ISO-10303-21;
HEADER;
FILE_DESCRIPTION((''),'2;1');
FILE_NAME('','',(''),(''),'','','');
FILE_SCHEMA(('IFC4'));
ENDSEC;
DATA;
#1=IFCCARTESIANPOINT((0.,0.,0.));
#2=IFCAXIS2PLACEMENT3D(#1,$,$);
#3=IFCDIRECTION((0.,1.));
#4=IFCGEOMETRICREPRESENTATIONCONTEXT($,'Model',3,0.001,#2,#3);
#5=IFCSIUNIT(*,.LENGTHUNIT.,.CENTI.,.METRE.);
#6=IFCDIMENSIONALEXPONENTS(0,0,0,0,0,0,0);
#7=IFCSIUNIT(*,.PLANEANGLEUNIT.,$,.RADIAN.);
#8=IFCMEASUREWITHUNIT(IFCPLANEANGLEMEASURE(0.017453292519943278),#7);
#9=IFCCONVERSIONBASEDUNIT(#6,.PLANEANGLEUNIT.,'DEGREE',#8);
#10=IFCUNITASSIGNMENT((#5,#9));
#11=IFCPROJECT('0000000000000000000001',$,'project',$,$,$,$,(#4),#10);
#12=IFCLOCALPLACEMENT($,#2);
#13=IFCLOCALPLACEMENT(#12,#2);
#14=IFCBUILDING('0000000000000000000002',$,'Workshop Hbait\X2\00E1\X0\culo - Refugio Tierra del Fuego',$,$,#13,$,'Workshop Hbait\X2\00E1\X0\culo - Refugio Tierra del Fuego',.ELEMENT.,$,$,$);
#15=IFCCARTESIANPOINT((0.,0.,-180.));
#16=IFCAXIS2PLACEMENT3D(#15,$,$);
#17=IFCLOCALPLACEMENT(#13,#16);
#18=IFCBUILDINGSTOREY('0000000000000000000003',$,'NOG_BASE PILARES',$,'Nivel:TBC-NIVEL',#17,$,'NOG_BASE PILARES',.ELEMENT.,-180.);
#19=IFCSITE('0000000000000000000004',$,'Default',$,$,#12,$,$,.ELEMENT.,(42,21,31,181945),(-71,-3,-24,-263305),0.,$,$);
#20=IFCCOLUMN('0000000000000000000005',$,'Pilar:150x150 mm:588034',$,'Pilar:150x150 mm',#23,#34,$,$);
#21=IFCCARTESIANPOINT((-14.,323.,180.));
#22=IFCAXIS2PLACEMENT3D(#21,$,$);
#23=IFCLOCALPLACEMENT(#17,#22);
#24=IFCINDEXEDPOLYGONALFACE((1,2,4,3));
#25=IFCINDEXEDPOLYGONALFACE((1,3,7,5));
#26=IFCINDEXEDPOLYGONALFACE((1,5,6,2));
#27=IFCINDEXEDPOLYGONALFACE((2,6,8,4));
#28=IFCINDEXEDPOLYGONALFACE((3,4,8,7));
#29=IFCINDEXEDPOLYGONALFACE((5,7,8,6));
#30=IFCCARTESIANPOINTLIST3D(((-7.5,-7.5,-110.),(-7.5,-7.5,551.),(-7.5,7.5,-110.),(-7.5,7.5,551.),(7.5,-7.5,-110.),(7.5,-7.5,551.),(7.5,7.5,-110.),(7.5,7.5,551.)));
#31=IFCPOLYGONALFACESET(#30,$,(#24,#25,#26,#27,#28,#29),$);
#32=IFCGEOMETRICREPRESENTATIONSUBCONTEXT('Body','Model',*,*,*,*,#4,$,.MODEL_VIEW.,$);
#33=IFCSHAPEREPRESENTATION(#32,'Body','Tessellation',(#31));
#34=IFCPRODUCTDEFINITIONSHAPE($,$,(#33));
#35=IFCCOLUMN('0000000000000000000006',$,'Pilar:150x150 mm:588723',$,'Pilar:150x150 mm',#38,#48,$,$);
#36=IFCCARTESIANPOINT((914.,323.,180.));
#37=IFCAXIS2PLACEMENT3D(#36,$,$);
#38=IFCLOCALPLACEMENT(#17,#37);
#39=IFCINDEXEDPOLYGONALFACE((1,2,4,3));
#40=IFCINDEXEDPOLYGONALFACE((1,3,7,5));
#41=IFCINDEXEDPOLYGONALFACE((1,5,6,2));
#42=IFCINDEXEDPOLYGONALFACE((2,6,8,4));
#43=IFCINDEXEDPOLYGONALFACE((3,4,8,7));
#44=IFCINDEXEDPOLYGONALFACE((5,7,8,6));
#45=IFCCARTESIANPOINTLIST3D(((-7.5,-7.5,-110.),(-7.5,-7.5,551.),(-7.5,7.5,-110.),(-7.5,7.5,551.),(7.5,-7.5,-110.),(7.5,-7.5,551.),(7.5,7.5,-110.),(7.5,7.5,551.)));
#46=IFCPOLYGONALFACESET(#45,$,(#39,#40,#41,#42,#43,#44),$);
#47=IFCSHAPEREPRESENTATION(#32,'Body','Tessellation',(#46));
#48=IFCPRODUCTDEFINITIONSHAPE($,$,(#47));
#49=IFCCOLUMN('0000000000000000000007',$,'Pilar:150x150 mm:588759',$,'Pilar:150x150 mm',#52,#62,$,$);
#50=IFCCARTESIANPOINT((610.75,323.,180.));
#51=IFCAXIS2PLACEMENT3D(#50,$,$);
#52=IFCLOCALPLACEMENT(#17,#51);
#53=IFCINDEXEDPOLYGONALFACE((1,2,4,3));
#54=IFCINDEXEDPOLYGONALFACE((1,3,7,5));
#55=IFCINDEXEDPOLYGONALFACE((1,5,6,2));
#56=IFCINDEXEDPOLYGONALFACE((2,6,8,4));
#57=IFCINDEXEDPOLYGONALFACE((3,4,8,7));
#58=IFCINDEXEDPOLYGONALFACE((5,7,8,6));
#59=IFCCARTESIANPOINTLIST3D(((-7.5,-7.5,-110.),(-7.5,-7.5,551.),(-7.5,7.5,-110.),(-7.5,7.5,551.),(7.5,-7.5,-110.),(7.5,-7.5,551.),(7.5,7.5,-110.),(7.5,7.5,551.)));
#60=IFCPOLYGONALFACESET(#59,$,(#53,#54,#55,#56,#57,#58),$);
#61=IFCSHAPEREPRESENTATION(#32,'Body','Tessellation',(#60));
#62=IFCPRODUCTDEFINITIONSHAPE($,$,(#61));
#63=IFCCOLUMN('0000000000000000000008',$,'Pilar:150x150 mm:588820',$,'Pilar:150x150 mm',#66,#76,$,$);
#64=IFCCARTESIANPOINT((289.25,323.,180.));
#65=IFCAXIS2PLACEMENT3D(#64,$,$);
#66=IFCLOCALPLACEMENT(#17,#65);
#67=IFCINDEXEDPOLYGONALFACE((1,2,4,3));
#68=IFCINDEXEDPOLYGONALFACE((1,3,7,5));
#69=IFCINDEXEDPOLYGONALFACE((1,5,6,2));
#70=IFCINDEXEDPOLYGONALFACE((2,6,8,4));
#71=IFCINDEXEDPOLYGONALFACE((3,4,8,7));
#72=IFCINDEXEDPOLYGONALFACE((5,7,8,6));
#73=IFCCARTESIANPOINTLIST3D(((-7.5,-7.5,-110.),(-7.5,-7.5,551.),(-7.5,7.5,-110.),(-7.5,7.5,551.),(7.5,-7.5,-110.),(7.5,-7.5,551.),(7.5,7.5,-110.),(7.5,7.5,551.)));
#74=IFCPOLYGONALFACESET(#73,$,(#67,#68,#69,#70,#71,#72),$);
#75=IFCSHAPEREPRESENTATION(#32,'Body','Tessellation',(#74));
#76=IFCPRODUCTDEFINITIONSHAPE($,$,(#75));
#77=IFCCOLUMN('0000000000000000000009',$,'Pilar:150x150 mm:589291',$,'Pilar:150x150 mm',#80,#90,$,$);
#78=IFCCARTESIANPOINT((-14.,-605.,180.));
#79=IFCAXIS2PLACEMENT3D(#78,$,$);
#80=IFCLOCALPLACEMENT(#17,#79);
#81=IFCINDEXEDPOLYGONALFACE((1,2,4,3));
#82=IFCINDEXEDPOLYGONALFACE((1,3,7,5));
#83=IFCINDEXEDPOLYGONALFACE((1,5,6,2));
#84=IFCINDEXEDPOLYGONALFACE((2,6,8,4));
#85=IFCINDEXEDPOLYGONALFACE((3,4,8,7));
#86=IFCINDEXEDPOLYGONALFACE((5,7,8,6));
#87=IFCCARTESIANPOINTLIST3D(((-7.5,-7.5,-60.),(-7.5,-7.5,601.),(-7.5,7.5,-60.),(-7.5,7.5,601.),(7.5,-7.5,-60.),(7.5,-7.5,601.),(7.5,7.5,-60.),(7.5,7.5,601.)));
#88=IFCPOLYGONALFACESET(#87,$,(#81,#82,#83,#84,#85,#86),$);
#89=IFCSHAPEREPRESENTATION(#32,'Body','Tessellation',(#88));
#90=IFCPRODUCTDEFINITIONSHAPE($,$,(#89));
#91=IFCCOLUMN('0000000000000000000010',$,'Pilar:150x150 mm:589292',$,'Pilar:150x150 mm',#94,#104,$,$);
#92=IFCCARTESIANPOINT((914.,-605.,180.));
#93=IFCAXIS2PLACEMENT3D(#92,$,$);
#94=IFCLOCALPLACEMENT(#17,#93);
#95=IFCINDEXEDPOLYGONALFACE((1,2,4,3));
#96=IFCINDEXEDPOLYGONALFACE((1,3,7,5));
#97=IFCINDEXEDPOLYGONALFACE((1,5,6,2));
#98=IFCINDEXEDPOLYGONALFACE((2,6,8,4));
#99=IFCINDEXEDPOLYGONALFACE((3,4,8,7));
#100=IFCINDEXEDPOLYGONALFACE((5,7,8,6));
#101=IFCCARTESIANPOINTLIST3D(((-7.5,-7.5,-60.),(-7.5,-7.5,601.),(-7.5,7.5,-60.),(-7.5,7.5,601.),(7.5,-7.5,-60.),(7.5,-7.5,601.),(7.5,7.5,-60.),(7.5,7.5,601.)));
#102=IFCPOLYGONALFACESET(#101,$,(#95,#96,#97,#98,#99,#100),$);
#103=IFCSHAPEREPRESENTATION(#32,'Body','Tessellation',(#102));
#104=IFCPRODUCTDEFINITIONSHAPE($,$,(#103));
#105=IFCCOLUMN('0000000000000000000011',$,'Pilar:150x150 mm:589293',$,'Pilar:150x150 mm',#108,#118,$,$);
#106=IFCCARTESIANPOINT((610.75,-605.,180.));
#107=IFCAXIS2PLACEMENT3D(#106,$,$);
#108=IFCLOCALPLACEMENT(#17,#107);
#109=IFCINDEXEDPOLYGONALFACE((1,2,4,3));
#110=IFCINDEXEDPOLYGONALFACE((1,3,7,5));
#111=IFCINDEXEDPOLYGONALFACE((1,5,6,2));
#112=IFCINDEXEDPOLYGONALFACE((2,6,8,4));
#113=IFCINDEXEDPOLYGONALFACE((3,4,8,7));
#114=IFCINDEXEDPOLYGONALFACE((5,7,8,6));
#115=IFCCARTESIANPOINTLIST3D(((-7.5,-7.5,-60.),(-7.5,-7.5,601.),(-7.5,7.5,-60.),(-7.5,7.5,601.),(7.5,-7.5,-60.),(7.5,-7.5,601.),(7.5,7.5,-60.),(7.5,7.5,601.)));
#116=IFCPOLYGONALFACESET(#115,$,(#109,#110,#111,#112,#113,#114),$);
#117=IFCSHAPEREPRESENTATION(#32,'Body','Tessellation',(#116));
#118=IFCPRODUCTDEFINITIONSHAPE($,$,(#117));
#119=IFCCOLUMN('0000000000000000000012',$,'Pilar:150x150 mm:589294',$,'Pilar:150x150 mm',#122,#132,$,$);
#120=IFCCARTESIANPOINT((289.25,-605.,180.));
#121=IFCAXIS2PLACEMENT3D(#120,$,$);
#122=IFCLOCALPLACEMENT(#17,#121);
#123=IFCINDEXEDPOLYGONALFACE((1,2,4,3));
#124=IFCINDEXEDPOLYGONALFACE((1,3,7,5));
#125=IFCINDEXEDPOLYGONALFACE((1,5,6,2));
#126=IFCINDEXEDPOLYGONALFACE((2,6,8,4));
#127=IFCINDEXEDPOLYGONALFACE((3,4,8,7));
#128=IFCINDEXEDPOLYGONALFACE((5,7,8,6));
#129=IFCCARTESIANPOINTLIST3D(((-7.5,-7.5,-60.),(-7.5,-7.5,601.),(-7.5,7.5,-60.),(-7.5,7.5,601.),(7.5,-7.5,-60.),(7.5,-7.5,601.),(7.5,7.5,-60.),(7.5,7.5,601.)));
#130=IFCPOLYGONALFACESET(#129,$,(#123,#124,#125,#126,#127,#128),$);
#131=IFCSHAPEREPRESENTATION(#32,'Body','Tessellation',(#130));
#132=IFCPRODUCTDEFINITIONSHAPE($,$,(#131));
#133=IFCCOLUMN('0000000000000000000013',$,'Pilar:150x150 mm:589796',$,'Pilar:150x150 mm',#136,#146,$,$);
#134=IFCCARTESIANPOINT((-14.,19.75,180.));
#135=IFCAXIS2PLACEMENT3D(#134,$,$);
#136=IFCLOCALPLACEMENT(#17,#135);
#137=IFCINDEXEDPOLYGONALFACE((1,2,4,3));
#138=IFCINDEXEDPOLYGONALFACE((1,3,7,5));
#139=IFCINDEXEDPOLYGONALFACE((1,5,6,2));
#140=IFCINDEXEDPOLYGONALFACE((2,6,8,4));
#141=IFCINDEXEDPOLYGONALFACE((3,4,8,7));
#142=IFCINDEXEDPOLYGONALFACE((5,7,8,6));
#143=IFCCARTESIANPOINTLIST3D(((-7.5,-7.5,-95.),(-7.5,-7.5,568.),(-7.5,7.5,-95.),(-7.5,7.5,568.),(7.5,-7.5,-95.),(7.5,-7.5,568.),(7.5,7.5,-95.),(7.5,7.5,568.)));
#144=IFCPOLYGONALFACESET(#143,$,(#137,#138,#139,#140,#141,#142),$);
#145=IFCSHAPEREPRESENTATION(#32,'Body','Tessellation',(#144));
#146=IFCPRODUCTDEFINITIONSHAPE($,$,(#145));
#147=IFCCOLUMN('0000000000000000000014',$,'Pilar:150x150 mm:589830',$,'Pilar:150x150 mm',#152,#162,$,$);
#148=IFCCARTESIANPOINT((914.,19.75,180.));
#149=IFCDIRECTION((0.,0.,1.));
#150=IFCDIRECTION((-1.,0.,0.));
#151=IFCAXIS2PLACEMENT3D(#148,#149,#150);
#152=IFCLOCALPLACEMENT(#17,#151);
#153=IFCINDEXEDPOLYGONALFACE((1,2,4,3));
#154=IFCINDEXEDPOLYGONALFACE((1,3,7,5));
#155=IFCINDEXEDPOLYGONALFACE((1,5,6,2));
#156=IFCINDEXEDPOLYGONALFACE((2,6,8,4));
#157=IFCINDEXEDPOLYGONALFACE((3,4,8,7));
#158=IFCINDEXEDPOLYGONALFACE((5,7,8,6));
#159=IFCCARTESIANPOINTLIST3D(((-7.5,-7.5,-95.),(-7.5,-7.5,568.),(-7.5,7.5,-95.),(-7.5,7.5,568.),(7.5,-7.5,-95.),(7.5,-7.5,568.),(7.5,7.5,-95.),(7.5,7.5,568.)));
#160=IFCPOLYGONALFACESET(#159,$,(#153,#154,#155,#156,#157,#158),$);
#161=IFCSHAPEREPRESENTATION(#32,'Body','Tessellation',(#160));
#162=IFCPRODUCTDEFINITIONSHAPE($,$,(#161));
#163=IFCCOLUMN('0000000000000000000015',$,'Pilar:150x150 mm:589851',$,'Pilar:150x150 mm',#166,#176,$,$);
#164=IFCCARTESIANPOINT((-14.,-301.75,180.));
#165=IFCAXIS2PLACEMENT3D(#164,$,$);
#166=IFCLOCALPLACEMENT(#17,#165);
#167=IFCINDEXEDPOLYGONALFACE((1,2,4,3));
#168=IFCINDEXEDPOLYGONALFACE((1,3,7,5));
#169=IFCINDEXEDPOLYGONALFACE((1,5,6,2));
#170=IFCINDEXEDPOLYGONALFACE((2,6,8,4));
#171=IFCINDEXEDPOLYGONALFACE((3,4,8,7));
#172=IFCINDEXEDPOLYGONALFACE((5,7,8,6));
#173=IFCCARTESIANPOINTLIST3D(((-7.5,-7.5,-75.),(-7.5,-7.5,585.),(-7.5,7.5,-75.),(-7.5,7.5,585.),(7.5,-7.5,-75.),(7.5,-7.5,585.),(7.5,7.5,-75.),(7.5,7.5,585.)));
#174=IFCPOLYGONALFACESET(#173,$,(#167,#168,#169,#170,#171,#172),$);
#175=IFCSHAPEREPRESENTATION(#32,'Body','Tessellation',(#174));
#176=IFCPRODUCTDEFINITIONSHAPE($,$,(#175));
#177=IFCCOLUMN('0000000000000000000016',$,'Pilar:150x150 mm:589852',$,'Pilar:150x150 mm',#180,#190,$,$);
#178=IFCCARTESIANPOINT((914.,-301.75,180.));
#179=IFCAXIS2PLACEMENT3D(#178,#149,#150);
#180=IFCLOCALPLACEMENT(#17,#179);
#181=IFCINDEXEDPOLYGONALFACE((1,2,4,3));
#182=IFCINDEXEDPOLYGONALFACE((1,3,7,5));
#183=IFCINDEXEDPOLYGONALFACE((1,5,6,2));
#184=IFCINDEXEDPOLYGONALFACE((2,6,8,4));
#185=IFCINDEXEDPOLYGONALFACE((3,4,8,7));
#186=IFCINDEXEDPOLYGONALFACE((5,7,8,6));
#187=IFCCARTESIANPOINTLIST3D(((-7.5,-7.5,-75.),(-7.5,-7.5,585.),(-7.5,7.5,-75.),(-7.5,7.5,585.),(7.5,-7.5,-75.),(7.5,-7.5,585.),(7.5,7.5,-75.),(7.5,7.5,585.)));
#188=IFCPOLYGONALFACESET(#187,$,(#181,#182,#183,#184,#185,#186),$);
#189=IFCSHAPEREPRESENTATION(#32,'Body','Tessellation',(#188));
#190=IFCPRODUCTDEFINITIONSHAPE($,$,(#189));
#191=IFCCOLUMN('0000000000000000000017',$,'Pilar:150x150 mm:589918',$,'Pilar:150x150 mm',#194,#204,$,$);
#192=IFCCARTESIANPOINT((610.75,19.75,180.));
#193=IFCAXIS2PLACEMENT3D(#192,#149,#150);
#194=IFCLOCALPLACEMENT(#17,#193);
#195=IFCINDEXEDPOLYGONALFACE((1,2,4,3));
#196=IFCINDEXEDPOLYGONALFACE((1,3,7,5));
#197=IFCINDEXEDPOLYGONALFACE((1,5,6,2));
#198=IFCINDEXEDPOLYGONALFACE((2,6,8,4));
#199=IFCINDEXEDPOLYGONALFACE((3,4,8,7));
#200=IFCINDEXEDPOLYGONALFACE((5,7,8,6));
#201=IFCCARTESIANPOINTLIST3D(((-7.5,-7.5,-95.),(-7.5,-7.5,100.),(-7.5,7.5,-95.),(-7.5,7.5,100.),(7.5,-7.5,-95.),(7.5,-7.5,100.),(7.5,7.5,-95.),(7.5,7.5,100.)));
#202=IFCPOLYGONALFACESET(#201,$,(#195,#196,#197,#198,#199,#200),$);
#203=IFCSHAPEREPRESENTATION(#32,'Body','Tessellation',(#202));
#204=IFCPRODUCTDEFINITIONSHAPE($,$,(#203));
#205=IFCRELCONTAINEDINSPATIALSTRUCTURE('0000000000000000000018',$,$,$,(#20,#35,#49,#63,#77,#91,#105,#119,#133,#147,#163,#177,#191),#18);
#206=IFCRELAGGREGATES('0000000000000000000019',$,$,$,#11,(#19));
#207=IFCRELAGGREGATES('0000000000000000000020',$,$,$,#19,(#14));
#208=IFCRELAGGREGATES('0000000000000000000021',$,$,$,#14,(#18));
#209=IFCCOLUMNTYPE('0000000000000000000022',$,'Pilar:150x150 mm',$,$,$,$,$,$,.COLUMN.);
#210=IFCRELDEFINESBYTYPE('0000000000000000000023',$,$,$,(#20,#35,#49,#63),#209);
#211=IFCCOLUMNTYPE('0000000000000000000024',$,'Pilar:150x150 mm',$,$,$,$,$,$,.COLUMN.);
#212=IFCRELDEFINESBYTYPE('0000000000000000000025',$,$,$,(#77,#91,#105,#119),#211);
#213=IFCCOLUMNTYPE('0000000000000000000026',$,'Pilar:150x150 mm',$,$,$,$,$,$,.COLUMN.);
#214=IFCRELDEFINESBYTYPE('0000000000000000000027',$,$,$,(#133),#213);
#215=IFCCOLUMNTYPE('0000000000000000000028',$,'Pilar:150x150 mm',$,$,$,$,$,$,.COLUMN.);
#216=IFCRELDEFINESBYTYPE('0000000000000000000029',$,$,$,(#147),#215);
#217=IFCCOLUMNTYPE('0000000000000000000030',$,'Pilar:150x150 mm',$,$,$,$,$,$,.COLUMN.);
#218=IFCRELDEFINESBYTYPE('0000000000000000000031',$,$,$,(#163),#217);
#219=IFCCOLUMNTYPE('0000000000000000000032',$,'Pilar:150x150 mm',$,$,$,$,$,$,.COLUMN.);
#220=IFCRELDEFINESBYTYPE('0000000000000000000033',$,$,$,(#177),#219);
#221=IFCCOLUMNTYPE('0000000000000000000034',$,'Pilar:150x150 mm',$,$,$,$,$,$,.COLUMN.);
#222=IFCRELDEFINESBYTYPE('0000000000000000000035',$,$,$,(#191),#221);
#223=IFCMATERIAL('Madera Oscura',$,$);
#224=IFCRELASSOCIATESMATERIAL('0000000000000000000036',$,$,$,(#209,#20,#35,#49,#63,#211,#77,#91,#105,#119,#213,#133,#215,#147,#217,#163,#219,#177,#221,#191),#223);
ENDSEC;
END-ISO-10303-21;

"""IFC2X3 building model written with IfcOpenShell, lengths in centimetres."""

from ifc_helpers import new_model, entity, si_unit, converted_unit, direction, frame, origin, origin_2d_with_axis, place, context, subcontext, project, spatial, rectangle, extrude, source, transform, mapped, material, type_object, type_shapes, element, save


model = new_model("IFC2X3")

# Units and contexts
model_context = context("Model", 3, precision=0.001, world=origin(), true_north=direction((0.0, 1.0)))
body_context = subcontext(model_context, "Body", "Model", "MODEL_VIEW")
ifc_project = project(units=[si_unit("LENGTHUNIT", "METRE", prefix="CENTI"), converted_unit("PLANEANGLEUNIT", "DEGREE", entity("IfcPlaneAngleMeasure", 0.017453292519943278), si_unit("PLANEANGLEUNIT", "RADIAN"), dimensions=[0, 0, 0, 0, 0, 0, 0])], contexts=[model_context])

# Site, building, storey
site_placement = place(None, origin())
site = spatial("IfcSite", under=ifc_project, at=site_placement, Name="Default", CompositionType="ELEMENT", RefLatitude=(42, 21, 31, 181945), RefLongitude=(-71, -3, -24, -263305), RefElevation=0.0)
building_placement = place(site_placement, origin())
building = spatial("IfcBuilding", under=site, at=building_placement, Name="Workshop Hbaitáculo - Refugio Tierra del Fuego", LongName="Workshop Hbaitáculo - Refugio Tierra del Fuego", CompositionType="ELEMENT")
storey_placement = place(building_placement, frame((0.0, 0.0, -180.0)))
storey = spatial("IfcBuildingStorey", under=building, at=storey_placement, Name="NOG_BASE PILARES", ObjectType="Nivel:TBC-NIVEL", LongName="NOG_BASE PILARES", CompositionType="ELEMENT", Elevation=-180.0)

# Columns
ifc_material = material(Name="Madera Oscura")
column_type_1 = type_object("IfcColumnType", Name="Pilar:150x150 mm", PredefinedType="COLUMN", material=ifc_material)
shared_shape_1 = source(origin(), body_context, "Body", "SweptSolid", [
    extrude(rectangle(XDim=15.0, YDim=15.0, at=origin_2d_with_axis()), frame((0.0, 0.0, -110.0), z_axis=(0.0, 0.0, 1.0), x_axis=(-1.0, 0.0, 0.0)), (0.0, 0.0, 1.0), 661.0),
])
type_shapes(column_type_1, [shared_shape_1])
for number, where, name in (
    (1, (-14.0, 323.0, 180.0), "Pilar:150x150 mm:588034"),
    (2, (914.0, 323.0, 180.0), "Pilar:150x150 mm:588723"),
    (3, (610.75, 323.0, 180.0), "Pilar:150x150 mm:588759"),
    (4, (289.25, 323.0, 180.0), "Pilar:150x150 mm:588820"),
):
    element("IfcColumn", number, at=place(storey_placement, frame(where)), inside=storey, type_object=column_type_1, material=ifc_material, Name=name, ObjectType="Pilar:150x150 mm", context=body_context, shape_type="MappedRepresentation", body=[
        mapped(shared_shape_1, transform((0.0, 0.0, 0.0), scale=1.0)),
    ])
column_type_2 = type_object("IfcColumnType", Name="Pilar:150x150 mm", PredefinedType="COLUMN", material=ifc_material)
shared_shape_2 = source(origin(), body_context, "Body", "SweptSolid", [
    extrude(rectangle(XDim=15.0, YDim=15.0, at=origin_2d_with_axis()), frame((0.0, 0.0, -60.0), z_axis=(0.0, 0.0, 1.0), x_axis=(0.0, 1.0, 0.0)), (0.0, 0.0, 1.0), 661.0),
])
type_shapes(column_type_2, [shared_shape_2])
for number, where, name in (
    (5, (-14.0, -605.0, 180.0), "Pilar:150x150 mm:589291"),
    (6, (914.0, -605.0, 180.0), "Pilar:150x150 mm:589292"),
    (7, (610.75, -605.0, 180.0), "Pilar:150x150 mm:589293"),
    (8, (289.25, -605.0, 180.0), "Pilar:150x150 mm:589294"),
):
    element("IfcColumn", number, at=place(storey_placement, frame(where)), inside=storey, type_object=column_type_2, material=ifc_material, Name=name, ObjectType="Pilar:150x150 mm", context=body_context, shape_type="MappedRepresentation", body=[
        mapped(shared_shape_2, transform((0.0, 0.0, 0.0), scale=1.0)),
    ])
column_type_3 = type_object("IfcColumnType", Name="Pilar:150x150 mm", PredefinedType="COLUMN", material=ifc_material)
shared_shape_3 = source(origin(), body_context, "Body", "SweptSolid", [
    extrude(rectangle(XDim=15.0, YDim=15.0, at=origin_2d_with_axis()), frame((0.0, 0.0, -95.0), z_axis=(0.0, 0.0, 1.0), x_axis=(-1.0, 0.0, 0.0)), (0.0, 0.0, 1.0), 663.0),
])
type_shapes(column_type_3, [shared_shape_3])
column_1_placement = place(storey_placement, frame((-14.0, 19.75, 180.0)))
element("IfcColumn", 9, at=column_1_placement, inside=storey, type_object=column_type_3, material=ifc_material, Name="Pilar:150x150 mm:589796", ObjectType="Pilar:150x150 mm", context=body_context, shape_type="MappedRepresentation", body=[
    mapped(shared_shape_3, transform((0.0, 0.0, 0.0), scale=1.0)),
])
column_type_4 = type_object("IfcColumnType", Name="Pilar:150x150 mm", PredefinedType="COLUMN", material=ifc_material)
shared_shape_4 = source(origin(), body_context, "Body", "SweptSolid", [
    extrude(rectangle(XDim=15.0, YDim=15.0, at=origin_2d_with_axis()), frame((0.0, 0.0, -95.0), z_axis=(0.0, 0.0, 1.0), x_axis=(0.0, 1.0, 0.0)), (0.0, 0.0, 1.0), 663.0),
])
type_shapes(column_type_4, [shared_shape_4])
column_2_placement = place(storey_placement, frame((914.0, 19.75, 180.0), z_axis=(0.0, 0.0, 1.0), x_axis=(-1.0, 0.0, 0.0)))
element("IfcColumn", 10, at=column_2_placement, inside=storey, type_object=column_type_4, material=ifc_material, Name="Pilar:150x150 mm:589830", ObjectType="Pilar:150x150 mm", context=body_context, shape_type="MappedRepresentation", body=[
    mapped(shared_shape_4, transform((0.0, 0.0, 0.0), scale=1.0)),
])
column_type_5 = type_object("IfcColumnType", Name="Pilar:150x150 mm", PredefinedType="COLUMN", material=ifc_material)
shared_shape_5 = source(origin(), body_context, "Body", "SweptSolid", [
    extrude(rectangle(XDim=15.0, YDim=15.0, at=origin_2d_with_axis()), frame((0.0, 0.0, -75.0), z_axis=(0.0, 0.0, 1.0), x_axis=(0.0, 1.0, 0.0)), (0.0, 0.0, 1.0), 660.0),
])
type_shapes(column_type_5, [shared_shape_5])
column_3_placement = place(storey_placement, frame((-14.0, -301.75, 180.0)))
element("IfcColumn", 11, at=column_3_placement, inside=storey, type_object=column_type_5, material=ifc_material, Name="Pilar:150x150 mm:589851", ObjectType="Pilar:150x150 mm", context=body_context, shape_type="MappedRepresentation", body=[
    mapped(shared_shape_5, transform((0.0, 0.0, 0.0), scale=1.0)),
])
column_type_6 = type_object("IfcColumnType", Name="Pilar:150x150 mm", PredefinedType="COLUMN", material=ifc_material)
shared_shape_6 = source(origin(), body_context, "Body", "SweptSolid", [
    extrude(rectangle(XDim=15.0, YDim=15.0, at=origin_2d_with_axis()), frame((0.0, 0.0, -75.0), z_axis=(0.0, 0.0, 1.0), x_axis=(-1.0, 0.0, 0.0)), (0.0, 0.0, 1.0), 660.0),
])
type_shapes(column_type_6, [shared_shape_6])
column_4_placement = place(storey_placement, frame((914.0, -301.75, 180.0), z_axis=(0.0, 0.0, 1.0), x_axis=(-1.0, 0.0, 0.0)))
element("IfcColumn", 12, at=column_4_placement, inside=storey, type_object=column_type_6, material=ifc_material, Name="Pilar:150x150 mm:589852", ObjectType="Pilar:150x150 mm", context=body_context, shape_type="MappedRepresentation", body=[
    mapped(shared_shape_6, transform((0.0, 0.0, 0.0), scale=1.0)),
])
column_type_7 = type_object("IfcColumnType", Name="Pilar:150x150 mm", PredefinedType="COLUMN", material=ifc_material)
shared_shape_7 = source(origin(), body_context, "Body", "SweptSolid", [
    extrude(rectangle(XDim=15.0, YDim=15.0, at=origin_2d_with_axis()), frame((0.0, 0.0, -95.0), z_axis=(0.0, 0.0, 1.0), x_axis=(0.0, 1.0, 0.0)), (0.0, 0.0, 1.0), 195.0),
])
type_shapes(column_type_7, [shared_shape_7])
column_5_placement = place(storey_placement, frame((610.75, 19.75, 180.0), z_axis=(0.0, 0.0, 1.0), x_axis=(-1.0, 0.0, 0.0)))
element("IfcColumn", 13, at=column_5_placement, inside=storey, type_object=column_type_7, material=ifc_material, Name="Pilar:150x150 mm:589918", ObjectType="Pilar:150x150 mm", context=body_context, shape_type="MappedRepresentation", body=[
    mapped(shared_shape_7, transform((0.0, 0.0, 0.0), scale=1.0)),
])

save(model, "model.ifc")
